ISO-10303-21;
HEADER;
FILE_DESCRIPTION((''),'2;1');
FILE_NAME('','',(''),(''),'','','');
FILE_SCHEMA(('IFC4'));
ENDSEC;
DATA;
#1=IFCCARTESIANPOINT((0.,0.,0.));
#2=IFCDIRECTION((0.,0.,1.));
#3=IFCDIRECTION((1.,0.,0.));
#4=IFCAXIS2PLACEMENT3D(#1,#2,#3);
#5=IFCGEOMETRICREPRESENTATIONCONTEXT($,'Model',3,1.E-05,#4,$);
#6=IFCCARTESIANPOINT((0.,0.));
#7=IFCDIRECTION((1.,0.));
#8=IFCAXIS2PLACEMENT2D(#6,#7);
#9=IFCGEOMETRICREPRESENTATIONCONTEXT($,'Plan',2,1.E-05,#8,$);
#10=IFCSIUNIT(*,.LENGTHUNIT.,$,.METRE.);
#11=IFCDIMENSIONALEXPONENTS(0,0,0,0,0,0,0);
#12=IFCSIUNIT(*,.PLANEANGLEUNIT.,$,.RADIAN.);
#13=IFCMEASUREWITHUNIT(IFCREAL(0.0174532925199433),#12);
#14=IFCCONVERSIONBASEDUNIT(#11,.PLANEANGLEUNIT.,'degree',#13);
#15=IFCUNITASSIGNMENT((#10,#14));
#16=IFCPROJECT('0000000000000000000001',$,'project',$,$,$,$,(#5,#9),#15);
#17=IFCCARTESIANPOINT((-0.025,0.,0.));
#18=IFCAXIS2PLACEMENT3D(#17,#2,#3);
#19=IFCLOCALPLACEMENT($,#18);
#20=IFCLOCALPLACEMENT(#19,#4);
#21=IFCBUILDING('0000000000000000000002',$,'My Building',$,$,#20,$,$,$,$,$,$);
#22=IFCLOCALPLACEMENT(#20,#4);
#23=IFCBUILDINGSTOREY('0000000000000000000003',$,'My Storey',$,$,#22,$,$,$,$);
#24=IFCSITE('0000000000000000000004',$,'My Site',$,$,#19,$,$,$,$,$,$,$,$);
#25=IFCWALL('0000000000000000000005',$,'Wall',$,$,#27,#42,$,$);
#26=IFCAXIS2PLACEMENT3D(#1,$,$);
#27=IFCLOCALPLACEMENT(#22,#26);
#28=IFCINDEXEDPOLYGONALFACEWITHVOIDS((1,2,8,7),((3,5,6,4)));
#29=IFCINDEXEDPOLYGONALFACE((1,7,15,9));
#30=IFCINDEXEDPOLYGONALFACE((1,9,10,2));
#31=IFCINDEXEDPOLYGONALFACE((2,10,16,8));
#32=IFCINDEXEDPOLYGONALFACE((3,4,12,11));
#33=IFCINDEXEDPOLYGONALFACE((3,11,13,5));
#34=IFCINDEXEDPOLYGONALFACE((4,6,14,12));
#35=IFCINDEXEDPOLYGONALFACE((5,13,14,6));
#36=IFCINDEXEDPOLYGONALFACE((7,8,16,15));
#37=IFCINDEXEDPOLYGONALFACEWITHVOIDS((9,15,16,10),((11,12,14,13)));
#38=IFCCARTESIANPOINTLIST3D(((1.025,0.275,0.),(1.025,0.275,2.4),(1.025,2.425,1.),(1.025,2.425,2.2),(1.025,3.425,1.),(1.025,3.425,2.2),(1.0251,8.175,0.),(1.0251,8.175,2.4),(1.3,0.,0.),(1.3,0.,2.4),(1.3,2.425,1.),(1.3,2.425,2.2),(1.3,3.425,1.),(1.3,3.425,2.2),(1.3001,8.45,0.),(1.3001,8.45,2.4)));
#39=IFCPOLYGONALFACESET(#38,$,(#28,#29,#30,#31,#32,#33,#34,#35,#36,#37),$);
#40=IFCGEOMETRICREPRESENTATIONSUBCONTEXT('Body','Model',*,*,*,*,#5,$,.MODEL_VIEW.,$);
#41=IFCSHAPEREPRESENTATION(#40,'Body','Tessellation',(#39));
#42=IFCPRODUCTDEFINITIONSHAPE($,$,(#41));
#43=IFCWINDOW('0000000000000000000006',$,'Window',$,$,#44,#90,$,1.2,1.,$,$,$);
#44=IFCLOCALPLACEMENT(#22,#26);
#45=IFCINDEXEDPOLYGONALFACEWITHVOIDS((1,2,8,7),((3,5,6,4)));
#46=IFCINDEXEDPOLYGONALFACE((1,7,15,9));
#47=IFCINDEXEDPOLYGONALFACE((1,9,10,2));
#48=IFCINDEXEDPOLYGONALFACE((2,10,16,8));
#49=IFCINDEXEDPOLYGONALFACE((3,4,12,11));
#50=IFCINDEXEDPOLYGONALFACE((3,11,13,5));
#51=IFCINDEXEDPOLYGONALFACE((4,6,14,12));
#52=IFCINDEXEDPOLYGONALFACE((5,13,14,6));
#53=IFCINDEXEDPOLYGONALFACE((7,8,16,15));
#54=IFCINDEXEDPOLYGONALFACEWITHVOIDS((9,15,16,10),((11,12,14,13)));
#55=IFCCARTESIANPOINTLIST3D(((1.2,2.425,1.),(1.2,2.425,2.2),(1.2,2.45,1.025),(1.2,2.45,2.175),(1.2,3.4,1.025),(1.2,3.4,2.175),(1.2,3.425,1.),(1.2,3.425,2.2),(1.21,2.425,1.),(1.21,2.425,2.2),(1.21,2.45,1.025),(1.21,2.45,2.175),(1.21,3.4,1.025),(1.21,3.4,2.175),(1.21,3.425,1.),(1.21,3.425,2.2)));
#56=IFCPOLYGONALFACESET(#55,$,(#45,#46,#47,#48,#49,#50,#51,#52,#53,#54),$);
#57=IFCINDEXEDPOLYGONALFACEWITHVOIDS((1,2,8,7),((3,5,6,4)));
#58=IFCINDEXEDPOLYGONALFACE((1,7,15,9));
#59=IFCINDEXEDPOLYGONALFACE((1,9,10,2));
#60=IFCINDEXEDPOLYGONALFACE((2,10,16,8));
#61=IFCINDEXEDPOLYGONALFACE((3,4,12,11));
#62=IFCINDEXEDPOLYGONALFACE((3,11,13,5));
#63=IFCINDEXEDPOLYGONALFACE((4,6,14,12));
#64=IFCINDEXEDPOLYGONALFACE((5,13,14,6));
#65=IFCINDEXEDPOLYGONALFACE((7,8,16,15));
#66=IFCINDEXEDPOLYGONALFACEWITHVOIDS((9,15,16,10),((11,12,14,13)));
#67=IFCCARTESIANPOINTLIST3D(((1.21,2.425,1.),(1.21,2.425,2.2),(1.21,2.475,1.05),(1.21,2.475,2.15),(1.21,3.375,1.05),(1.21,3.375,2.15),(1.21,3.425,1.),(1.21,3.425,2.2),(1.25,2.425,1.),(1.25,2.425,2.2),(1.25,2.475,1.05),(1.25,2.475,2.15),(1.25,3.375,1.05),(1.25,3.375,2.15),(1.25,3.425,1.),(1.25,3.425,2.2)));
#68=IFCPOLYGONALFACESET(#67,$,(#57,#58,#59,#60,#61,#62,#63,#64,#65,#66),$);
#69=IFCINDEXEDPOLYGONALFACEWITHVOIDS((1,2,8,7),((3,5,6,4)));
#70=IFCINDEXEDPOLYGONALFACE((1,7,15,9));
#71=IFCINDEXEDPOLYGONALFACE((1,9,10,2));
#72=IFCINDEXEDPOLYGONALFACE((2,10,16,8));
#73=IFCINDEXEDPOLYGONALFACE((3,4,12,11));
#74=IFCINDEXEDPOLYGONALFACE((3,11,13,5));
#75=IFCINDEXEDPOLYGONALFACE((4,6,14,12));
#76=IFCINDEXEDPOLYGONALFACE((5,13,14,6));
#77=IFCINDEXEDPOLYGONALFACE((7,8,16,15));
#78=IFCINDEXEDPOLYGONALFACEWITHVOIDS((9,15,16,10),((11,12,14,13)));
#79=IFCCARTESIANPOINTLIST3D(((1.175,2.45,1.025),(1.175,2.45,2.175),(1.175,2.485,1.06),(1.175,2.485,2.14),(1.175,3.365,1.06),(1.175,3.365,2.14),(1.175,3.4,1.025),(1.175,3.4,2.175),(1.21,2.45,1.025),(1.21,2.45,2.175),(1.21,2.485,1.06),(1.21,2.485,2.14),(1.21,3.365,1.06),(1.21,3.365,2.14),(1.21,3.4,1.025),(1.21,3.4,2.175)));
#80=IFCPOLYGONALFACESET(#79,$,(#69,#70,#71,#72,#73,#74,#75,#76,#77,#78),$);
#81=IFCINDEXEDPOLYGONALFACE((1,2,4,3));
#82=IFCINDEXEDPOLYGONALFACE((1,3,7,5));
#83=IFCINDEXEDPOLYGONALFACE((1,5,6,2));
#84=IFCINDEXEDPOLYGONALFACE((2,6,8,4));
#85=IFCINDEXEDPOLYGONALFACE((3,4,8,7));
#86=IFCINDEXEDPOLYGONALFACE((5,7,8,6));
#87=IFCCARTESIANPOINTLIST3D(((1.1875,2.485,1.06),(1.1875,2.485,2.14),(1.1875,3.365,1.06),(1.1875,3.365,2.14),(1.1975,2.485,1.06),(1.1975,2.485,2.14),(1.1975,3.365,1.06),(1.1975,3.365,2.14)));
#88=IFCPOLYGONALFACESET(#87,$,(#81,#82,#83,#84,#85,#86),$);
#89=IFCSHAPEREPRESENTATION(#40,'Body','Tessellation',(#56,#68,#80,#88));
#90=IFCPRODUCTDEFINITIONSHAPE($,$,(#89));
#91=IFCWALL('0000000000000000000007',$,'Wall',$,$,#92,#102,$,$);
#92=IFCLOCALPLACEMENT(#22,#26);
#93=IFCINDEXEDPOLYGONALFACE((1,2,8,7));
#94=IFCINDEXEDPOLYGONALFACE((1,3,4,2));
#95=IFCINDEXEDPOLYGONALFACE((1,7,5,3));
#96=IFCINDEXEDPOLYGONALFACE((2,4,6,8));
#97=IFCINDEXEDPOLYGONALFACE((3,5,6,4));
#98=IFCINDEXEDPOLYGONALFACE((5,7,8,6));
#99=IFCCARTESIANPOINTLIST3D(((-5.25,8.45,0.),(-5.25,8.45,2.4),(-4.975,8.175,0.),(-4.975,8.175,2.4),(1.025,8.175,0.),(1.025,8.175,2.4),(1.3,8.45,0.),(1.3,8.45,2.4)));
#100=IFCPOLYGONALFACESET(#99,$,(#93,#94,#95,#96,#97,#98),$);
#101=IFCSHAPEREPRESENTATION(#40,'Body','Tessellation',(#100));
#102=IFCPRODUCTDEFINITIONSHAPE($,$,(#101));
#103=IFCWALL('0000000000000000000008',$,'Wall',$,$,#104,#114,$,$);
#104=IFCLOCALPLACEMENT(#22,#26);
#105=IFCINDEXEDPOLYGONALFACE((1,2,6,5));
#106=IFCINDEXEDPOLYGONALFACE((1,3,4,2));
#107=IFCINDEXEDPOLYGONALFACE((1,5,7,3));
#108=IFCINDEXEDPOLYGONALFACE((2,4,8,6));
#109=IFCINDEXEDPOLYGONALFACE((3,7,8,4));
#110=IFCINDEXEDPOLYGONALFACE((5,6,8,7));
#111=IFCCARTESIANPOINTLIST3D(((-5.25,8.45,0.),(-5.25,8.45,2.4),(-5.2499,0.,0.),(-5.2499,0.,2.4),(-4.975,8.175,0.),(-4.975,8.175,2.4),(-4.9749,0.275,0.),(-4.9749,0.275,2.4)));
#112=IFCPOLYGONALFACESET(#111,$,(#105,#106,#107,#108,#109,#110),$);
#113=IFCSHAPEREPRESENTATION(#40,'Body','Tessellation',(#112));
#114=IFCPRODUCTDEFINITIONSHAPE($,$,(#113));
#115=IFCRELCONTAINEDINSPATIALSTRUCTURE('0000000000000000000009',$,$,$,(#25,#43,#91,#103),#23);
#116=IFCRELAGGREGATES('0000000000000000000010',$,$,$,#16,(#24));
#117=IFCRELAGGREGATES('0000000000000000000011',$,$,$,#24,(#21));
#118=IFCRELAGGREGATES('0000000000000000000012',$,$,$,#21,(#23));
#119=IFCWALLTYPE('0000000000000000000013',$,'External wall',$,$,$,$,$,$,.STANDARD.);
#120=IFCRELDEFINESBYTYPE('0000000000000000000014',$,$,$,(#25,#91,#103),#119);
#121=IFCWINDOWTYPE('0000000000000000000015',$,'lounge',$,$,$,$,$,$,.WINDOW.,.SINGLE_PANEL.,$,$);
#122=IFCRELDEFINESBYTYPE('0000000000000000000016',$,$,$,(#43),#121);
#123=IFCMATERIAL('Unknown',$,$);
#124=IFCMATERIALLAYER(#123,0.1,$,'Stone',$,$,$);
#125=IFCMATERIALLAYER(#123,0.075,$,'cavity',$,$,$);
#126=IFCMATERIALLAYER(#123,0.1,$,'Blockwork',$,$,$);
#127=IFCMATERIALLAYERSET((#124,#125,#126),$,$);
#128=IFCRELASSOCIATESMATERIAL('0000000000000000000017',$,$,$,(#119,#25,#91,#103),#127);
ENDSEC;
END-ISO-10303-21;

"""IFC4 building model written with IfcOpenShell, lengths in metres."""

from ifc_helpers import new_model, entity, si_unit, converted_unit, frame, origin_with_axes, origin_2d_with_axis, place, context, subcontext, project, spatial, line, indexed_curve, outline, extrude, clip, halfspace, shape, source, transform, mapped, material, layer, layer_set, layer_usage, type_object, type_shapes, element, fill, save


model = new_model("IFC4")

# Units and contexts
model_context = context("Model", 3, precision=1e-05, world=origin_with_axes())
plan_context = context("Plan", 2, precision=1e-05, world=origin_2d_with_axis())
body_context_1 = subcontext(model_context, "Body", "Model", "MODEL_VIEW")
body_context_2 = subcontext(plan_context, "Body", "Plan", "PLAN_VIEW")
ifc_project = project(units=[si_unit("LENGTHUNIT", "METRE"), converted_unit("PLANEANGLEUNIT", "degree", entity("IfcReal", 0.0174532925199433), si_unit("PLANEANGLEUNIT", "RADIAN"), dimensions=[0, 0, 0, 0, 0, 0, 0])], contexts=[model_context, plan_context])

# Site, building, storey
site_placement = place(None, frame((-0.025, 0.0, 0.0), z_axis=(0.0, 0.0, 1.0), x_axis=(1.0, 0.0, 0.0)))
site = spatial("IfcSite", under=ifc_project, at=site_placement, Name="My Site")
building_placement = place(site_placement, origin_with_axes())
building = spatial("IfcBuilding", under=site, at=building_placement, Name="My Building")
storey_placement = place(building_placement, origin_with_axes())
storey = spatial("IfcBuildingStorey", under=building, at=storey_placement, Name="My Storey")

# Shared definitions
ifc_material = material(Name="Unknown")
ifc_layer_1 = layer(ifc_material, 0.1, Name="Stone")
ifc_layer_2 = layer(ifc_material, 0.075, Name="cavity")
ifc_layer_3 = layer(ifc_material, 0.1, Name="Blockwork")
ifc_layer_set_1 = layer_set([ifc_layer_1, ifc_layer_2, ifc_layer_3])
wall_type_1 = type_object("IfcWallType", Name="External wall", PredefinedType="STANDARD", material=ifc_layer_set_1)

# Wall, opening, window
ifc_layer_usage_1 = layer_usage(ifc_layer_set_1, "AXIS2", "POSITIVE", 0.0)
wall_1_placement = place(storey_placement, frame((1.3, 0.0, 0.0), z_axis=(0.0, 0.0, 1.0), x_axis=(0.0, 1.0, 0.0)))
wall_1 = element("IfcWall", 1, at=wall_1_placement, inside=storey, type_object=wall_type_1, material=ifc_layer_usage_1, Name="Wall", context=body_context_1, shape_type="Clipping", body=[
    clip(clip(extrude(outline(indexed_curve([(0.0, 0.0), (0.0, 0.275), (8.45, 0.275), (8.45, 0.0), (0.0, 0.0)], self_intersect=False)), origin_with_axes(), (0.0, 0.0, 1.0), 2.4), halfspace(frame((0.0, 0.0, 0.0), z_axis=(-0.707107, 0.707107, 0.0), x_axis=(0.707107, 0.707107, 0.0)), False)), halfspace(frame((8.45, 0.0, 0.0), z_axis=(0.707107, 0.707106, 0.0), x_axis=(-0.707106, 0.707107, 0.0)), False)),
])
shared_shape_1 = source(origin_with_axes(), body_context_1, "Body", "SweptSolid", [
    extrude(outline(indexed_curve([(0.0, 0.0), (1.0, 0.0), (1.0, 1.2), (0.0, 1.2)], segments=[line(1, 2, 3, 4, 1)])), frame((0.0, -0.6, 0.0), z_axis=(0.0, -1.0, 0.0), x_axis=(1.0, 0.0, 0.0)), (0.0, 0.0, -1.0), 1.2),
])
opening_1_placement = place(wall_1_placement, frame((2.425, 0.0, 1.0), z_axis=(0.0, 0.0, 1.0), x_axis=(1.0, 0.0, 0.0)))
opening_1 = element("IfcOpeningElement", 2, at=opening_1_placement, cuts=wall_1, PredefinedType="OPENING", context=body_context_1, shape_type="MappedRepresentation", body=[
    mapped(shared_shape_1, transform((0.0, 0.0, 0.0), x_axis=(1.0, 0.0, 0.0), y_axis=(0.0, 1.0, 0.0), z_axis=(0.0, 0.0, 1.0), scale=1.0)),
])
window_type_1 = type_object("IfcWindowType", Name="lounge", PartitioningType="SINGLE_PANEL", PredefinedType="WINDOW")
shared_shape_2 = source(origin_with_axes(), body_context_1, "Body", "SweptSolid", [
    extrude(outline(indexed_curve([(0.0, 0.0), (1.0, 0.0), (1.0, 1.2), (0.0, 1.2)], segments=[line(1, 2, 3, 4, 1)]), holes=[indexed_curve([(0.025, 0.025), (0.975, 0.025), (0.975, 1.175), (0.025, 1.175)], segments=[line(1, 2, 3, 4, 1)])]), frame((0.0, 0.09, 0.0), z_axis=(0.0, -1.0, 0.0), x_axis=(1.0, 0.0, 0.0)), (0.0, 0.0, -1.0), 0.01),
    extrude(outline(indexed_curve([(0.0, 0.0), (1.0, 0.0), (1.0, 1.2), (0.0, 1.2)], segments=[line(1, 2, 3, 4, 1)]), holes=[indexed_curve([(0.05, 0.05), (0.95, 0.05), (0.95, 1.15), (0.05, 1.15)], segments=[line(1, 2, 3, 4, 1)])]), frame((0.0, 0.05, 0.0), z_axis=(0.0, -1.0, 0.0), x_axis=(1.0, 0.0, 0.0)), (0.0, 0.0, -1.0), 0.04),
    extrude(outline(indexed_curve([(0.0, 0.0), (0.95, 0.0), (0.95, 1.15), (0.0, 1.15)], segments=[line(1, 2, 3, 4, 1)]), holes=[indexed_curve([(0.035, 0.035), (0.915, 0.035), (0.915, 1.115), (0.035, 1.115)], segments=[line(1, 2, 3, 4, 1)])]), frame((0.025, 0.09, 0.025), z_axis=(0.0, -1.0, 0.0), x_axis=(1.0, 0.0, 0.0)), (0.0, 0.0, -1.0), 0.035),
    extrude(outline(indexed_curve([(0.035, 0.035), (0.915, 0.035), (0.915, 1.115), (0.035, 1.115)], segments=[line(1, 2, 3, 4, 1)])), frame((0.025, 0.1025, 0.025), z_axis=(0.0, -1.0, 0.0), x_axis=(1.0, 0.0, 0.0)), (0.0, 0.0, -1.0), 0.01),
])
shared_shape_3 = source(origin_with_axes(), body_context_2, "Body", "Curve2D", [
    entity("IfcIndexedPolyCurve", entity("IfcCartesianPointList2D", [[0.05, 0.05], [0.95, 0.05]])),
    entity("IfcIndexedPolyCurve", entity("IfcCartesianPointList2D", [[0.0, 0.1], [0.025, 0.1], [0.025, 0.09], [0.05, 0.09], [0.05, 0.05], [0.0, 0.05]]), [entity("IfcLineIndex", [1, 2, 3, 4, 5, 6, 1])]),
    entity("IfcIndexedPolyCurve", entity("IfcCartesianPointList2D", [[1.0, 0.1], [0.975, 0.1], [0.975, 0.09], [0.95, 0.09], [0.95, 0.05], [1.0, 0.05]]), [entity("IfcLineIndex", [1, 2, 3, 4, 5, 6, 1])]),
    entity("IfcIndexedPolyCurve", entity("IfcCartesianPointList2D", [[0.025, 0.09], [0.06, 0.09], [0.06, 0.125], [0.025, 0.125]]), [entity("IfcLineIndex", [1, 2, 3, 4, 1])]),
    entity("IfcIndexedPolyCurve", entity("IfcCartesianPointList2D", [[0.975, 0.09], [0.94, 0.09], [0.94, 0.125], [0.975, 0.125]]), [entity("IfcLineIndex", [1, 2, 3, 4, 1])]),
    entity("IfcIndexedPolyCurve", entity("IfcCartesianPointList2D", [[0.06, 0.09], [0.94, 0.09]])),
    entity("IfcIndexedPolyCurve", entity("IfcCartesianPointList2D", [[0.06, 0.125], [0.94, 0.125]])),
    entity("IfcIndexedPolyCurve", entity("IfcCartesianPointList2D", [[0.06, 0.1075], [0.94, 0.1075]])),
])
type_shapes(window_type_1, [shared_shape_2, shared_shape_3])
window_1_placement = place(opening_1_placement, frame((0.0, 0.0, 0.0), z_axis=(0.0, 0.0, 1.0), x_axis=(1.0, 0.0, 0.0)))
window_1 = element("IfcWindow", 3, at=window_1_placement, inside=storey, type_object=window_type_1, Name="Window", OverallHeight=1.2, OverallWidth=1.0, shapes=[
    shape(body_context_1, "Body", "MappedRepresentation", [mapped(shared_shape_2, transform((0.0, 0.0, 0.0), x_axis=(1.0, 0.0, 0.0), y_axis=(0.0, 1.0, 0.0), z_axis=(0.0, 0.0, 1.0), scale=1.0))]),
    shape(body_context_2, "Body", "MappedRepresentation", [mapped(shared_shape_3, transform((0.0, 0.0, 0.0), x_axis=(1.0, 0.0, 0.0), y_axis=(0.0, 1.0, 0.0), z_axis=(0.0, 0.0, 1.0), scale=1.0))]),
])
fill(opening_1, window_1)

# Walls
ifc_layer_usage_2 = layer_usage(ifc_layer_set_1, "AXIS2", "POSITIVE", 0.0)
wall_2_placement = place(storey_placement, frame((1.3, 8.45, 0.0), z_axis=(0.0, 0.0, 1.0), x_axis=(-1.0, 0.0, 0.0)))
element("IfcWall", 4, at=wall_2_placement, inside=storey, type_object=wall_type_1, material=ifc_layer_usage_2, Name="Wall", context=body_context_1, shape_type="Clipping", body=[
    clip(clip(extrude(outline(indexed_curve([(0.0, 0.0), (0.0, 0.275), (6.55, 0.275), (6.55, 0.0), (0.0, 0.0)], self_intersect=False)), origin_with_axes(), (0.0, 0.0, 1.0), 2.4), halfspace(frame((6.55, 0.0, 0.0), z_axis=(0.707106, 0.707107, 0.0), x_axis=(-0.707107, 0.707106, 0.0)), False)), halfspace(frame((0.0, 0.0, 0.0), z_axis=(-0.707106, 0.707107, 0.0), x_axis=(0.707107, 0.707106, 0.0)), False)),
])
ifc_layer_usage_3 = layer_usage(ifc_layer_set_1, "AXIS2", "POSITIVE", 0.0)
wall_3_placement = place(storey_placement, frame((-5.25, 8.45, 0.0), z_axis=(0.0, 0.0, 1.0), x_axis=(0.0, -1.0, 0.0)))
element("IfcWall", 5, at=wall_3_placement, inside=storey, type_object=wall_type_1, material=ifc_layer_usage_3, Name="Wall", context=body_context_1, shape_type="Clipping", body=[
    clip(clip(extrude(outline(indexed_curve([(0.0, 0.0), (0.0, 0.275), (8.45, 0.275), (8.45, 0.0), (0.0, 0.0)], self_intersect=False)), origin_with_axes(), (0.0, 0.0, 1.0), 2.4), halfspace(frame((0.0, 0.0, 0.0), z_axis=(-0.707107, 0.707106, 0.0), x_axis=(0.707106, 0.707107, 0.0)), False)), halfspace(frame((8.45, 0.0, 0.0), z_axis=(0.707107, 0.707106, 0.0), x_axis=(-0.707106, 0.707107, 0.0)), False)),
])

save(model, "model.ifc")
